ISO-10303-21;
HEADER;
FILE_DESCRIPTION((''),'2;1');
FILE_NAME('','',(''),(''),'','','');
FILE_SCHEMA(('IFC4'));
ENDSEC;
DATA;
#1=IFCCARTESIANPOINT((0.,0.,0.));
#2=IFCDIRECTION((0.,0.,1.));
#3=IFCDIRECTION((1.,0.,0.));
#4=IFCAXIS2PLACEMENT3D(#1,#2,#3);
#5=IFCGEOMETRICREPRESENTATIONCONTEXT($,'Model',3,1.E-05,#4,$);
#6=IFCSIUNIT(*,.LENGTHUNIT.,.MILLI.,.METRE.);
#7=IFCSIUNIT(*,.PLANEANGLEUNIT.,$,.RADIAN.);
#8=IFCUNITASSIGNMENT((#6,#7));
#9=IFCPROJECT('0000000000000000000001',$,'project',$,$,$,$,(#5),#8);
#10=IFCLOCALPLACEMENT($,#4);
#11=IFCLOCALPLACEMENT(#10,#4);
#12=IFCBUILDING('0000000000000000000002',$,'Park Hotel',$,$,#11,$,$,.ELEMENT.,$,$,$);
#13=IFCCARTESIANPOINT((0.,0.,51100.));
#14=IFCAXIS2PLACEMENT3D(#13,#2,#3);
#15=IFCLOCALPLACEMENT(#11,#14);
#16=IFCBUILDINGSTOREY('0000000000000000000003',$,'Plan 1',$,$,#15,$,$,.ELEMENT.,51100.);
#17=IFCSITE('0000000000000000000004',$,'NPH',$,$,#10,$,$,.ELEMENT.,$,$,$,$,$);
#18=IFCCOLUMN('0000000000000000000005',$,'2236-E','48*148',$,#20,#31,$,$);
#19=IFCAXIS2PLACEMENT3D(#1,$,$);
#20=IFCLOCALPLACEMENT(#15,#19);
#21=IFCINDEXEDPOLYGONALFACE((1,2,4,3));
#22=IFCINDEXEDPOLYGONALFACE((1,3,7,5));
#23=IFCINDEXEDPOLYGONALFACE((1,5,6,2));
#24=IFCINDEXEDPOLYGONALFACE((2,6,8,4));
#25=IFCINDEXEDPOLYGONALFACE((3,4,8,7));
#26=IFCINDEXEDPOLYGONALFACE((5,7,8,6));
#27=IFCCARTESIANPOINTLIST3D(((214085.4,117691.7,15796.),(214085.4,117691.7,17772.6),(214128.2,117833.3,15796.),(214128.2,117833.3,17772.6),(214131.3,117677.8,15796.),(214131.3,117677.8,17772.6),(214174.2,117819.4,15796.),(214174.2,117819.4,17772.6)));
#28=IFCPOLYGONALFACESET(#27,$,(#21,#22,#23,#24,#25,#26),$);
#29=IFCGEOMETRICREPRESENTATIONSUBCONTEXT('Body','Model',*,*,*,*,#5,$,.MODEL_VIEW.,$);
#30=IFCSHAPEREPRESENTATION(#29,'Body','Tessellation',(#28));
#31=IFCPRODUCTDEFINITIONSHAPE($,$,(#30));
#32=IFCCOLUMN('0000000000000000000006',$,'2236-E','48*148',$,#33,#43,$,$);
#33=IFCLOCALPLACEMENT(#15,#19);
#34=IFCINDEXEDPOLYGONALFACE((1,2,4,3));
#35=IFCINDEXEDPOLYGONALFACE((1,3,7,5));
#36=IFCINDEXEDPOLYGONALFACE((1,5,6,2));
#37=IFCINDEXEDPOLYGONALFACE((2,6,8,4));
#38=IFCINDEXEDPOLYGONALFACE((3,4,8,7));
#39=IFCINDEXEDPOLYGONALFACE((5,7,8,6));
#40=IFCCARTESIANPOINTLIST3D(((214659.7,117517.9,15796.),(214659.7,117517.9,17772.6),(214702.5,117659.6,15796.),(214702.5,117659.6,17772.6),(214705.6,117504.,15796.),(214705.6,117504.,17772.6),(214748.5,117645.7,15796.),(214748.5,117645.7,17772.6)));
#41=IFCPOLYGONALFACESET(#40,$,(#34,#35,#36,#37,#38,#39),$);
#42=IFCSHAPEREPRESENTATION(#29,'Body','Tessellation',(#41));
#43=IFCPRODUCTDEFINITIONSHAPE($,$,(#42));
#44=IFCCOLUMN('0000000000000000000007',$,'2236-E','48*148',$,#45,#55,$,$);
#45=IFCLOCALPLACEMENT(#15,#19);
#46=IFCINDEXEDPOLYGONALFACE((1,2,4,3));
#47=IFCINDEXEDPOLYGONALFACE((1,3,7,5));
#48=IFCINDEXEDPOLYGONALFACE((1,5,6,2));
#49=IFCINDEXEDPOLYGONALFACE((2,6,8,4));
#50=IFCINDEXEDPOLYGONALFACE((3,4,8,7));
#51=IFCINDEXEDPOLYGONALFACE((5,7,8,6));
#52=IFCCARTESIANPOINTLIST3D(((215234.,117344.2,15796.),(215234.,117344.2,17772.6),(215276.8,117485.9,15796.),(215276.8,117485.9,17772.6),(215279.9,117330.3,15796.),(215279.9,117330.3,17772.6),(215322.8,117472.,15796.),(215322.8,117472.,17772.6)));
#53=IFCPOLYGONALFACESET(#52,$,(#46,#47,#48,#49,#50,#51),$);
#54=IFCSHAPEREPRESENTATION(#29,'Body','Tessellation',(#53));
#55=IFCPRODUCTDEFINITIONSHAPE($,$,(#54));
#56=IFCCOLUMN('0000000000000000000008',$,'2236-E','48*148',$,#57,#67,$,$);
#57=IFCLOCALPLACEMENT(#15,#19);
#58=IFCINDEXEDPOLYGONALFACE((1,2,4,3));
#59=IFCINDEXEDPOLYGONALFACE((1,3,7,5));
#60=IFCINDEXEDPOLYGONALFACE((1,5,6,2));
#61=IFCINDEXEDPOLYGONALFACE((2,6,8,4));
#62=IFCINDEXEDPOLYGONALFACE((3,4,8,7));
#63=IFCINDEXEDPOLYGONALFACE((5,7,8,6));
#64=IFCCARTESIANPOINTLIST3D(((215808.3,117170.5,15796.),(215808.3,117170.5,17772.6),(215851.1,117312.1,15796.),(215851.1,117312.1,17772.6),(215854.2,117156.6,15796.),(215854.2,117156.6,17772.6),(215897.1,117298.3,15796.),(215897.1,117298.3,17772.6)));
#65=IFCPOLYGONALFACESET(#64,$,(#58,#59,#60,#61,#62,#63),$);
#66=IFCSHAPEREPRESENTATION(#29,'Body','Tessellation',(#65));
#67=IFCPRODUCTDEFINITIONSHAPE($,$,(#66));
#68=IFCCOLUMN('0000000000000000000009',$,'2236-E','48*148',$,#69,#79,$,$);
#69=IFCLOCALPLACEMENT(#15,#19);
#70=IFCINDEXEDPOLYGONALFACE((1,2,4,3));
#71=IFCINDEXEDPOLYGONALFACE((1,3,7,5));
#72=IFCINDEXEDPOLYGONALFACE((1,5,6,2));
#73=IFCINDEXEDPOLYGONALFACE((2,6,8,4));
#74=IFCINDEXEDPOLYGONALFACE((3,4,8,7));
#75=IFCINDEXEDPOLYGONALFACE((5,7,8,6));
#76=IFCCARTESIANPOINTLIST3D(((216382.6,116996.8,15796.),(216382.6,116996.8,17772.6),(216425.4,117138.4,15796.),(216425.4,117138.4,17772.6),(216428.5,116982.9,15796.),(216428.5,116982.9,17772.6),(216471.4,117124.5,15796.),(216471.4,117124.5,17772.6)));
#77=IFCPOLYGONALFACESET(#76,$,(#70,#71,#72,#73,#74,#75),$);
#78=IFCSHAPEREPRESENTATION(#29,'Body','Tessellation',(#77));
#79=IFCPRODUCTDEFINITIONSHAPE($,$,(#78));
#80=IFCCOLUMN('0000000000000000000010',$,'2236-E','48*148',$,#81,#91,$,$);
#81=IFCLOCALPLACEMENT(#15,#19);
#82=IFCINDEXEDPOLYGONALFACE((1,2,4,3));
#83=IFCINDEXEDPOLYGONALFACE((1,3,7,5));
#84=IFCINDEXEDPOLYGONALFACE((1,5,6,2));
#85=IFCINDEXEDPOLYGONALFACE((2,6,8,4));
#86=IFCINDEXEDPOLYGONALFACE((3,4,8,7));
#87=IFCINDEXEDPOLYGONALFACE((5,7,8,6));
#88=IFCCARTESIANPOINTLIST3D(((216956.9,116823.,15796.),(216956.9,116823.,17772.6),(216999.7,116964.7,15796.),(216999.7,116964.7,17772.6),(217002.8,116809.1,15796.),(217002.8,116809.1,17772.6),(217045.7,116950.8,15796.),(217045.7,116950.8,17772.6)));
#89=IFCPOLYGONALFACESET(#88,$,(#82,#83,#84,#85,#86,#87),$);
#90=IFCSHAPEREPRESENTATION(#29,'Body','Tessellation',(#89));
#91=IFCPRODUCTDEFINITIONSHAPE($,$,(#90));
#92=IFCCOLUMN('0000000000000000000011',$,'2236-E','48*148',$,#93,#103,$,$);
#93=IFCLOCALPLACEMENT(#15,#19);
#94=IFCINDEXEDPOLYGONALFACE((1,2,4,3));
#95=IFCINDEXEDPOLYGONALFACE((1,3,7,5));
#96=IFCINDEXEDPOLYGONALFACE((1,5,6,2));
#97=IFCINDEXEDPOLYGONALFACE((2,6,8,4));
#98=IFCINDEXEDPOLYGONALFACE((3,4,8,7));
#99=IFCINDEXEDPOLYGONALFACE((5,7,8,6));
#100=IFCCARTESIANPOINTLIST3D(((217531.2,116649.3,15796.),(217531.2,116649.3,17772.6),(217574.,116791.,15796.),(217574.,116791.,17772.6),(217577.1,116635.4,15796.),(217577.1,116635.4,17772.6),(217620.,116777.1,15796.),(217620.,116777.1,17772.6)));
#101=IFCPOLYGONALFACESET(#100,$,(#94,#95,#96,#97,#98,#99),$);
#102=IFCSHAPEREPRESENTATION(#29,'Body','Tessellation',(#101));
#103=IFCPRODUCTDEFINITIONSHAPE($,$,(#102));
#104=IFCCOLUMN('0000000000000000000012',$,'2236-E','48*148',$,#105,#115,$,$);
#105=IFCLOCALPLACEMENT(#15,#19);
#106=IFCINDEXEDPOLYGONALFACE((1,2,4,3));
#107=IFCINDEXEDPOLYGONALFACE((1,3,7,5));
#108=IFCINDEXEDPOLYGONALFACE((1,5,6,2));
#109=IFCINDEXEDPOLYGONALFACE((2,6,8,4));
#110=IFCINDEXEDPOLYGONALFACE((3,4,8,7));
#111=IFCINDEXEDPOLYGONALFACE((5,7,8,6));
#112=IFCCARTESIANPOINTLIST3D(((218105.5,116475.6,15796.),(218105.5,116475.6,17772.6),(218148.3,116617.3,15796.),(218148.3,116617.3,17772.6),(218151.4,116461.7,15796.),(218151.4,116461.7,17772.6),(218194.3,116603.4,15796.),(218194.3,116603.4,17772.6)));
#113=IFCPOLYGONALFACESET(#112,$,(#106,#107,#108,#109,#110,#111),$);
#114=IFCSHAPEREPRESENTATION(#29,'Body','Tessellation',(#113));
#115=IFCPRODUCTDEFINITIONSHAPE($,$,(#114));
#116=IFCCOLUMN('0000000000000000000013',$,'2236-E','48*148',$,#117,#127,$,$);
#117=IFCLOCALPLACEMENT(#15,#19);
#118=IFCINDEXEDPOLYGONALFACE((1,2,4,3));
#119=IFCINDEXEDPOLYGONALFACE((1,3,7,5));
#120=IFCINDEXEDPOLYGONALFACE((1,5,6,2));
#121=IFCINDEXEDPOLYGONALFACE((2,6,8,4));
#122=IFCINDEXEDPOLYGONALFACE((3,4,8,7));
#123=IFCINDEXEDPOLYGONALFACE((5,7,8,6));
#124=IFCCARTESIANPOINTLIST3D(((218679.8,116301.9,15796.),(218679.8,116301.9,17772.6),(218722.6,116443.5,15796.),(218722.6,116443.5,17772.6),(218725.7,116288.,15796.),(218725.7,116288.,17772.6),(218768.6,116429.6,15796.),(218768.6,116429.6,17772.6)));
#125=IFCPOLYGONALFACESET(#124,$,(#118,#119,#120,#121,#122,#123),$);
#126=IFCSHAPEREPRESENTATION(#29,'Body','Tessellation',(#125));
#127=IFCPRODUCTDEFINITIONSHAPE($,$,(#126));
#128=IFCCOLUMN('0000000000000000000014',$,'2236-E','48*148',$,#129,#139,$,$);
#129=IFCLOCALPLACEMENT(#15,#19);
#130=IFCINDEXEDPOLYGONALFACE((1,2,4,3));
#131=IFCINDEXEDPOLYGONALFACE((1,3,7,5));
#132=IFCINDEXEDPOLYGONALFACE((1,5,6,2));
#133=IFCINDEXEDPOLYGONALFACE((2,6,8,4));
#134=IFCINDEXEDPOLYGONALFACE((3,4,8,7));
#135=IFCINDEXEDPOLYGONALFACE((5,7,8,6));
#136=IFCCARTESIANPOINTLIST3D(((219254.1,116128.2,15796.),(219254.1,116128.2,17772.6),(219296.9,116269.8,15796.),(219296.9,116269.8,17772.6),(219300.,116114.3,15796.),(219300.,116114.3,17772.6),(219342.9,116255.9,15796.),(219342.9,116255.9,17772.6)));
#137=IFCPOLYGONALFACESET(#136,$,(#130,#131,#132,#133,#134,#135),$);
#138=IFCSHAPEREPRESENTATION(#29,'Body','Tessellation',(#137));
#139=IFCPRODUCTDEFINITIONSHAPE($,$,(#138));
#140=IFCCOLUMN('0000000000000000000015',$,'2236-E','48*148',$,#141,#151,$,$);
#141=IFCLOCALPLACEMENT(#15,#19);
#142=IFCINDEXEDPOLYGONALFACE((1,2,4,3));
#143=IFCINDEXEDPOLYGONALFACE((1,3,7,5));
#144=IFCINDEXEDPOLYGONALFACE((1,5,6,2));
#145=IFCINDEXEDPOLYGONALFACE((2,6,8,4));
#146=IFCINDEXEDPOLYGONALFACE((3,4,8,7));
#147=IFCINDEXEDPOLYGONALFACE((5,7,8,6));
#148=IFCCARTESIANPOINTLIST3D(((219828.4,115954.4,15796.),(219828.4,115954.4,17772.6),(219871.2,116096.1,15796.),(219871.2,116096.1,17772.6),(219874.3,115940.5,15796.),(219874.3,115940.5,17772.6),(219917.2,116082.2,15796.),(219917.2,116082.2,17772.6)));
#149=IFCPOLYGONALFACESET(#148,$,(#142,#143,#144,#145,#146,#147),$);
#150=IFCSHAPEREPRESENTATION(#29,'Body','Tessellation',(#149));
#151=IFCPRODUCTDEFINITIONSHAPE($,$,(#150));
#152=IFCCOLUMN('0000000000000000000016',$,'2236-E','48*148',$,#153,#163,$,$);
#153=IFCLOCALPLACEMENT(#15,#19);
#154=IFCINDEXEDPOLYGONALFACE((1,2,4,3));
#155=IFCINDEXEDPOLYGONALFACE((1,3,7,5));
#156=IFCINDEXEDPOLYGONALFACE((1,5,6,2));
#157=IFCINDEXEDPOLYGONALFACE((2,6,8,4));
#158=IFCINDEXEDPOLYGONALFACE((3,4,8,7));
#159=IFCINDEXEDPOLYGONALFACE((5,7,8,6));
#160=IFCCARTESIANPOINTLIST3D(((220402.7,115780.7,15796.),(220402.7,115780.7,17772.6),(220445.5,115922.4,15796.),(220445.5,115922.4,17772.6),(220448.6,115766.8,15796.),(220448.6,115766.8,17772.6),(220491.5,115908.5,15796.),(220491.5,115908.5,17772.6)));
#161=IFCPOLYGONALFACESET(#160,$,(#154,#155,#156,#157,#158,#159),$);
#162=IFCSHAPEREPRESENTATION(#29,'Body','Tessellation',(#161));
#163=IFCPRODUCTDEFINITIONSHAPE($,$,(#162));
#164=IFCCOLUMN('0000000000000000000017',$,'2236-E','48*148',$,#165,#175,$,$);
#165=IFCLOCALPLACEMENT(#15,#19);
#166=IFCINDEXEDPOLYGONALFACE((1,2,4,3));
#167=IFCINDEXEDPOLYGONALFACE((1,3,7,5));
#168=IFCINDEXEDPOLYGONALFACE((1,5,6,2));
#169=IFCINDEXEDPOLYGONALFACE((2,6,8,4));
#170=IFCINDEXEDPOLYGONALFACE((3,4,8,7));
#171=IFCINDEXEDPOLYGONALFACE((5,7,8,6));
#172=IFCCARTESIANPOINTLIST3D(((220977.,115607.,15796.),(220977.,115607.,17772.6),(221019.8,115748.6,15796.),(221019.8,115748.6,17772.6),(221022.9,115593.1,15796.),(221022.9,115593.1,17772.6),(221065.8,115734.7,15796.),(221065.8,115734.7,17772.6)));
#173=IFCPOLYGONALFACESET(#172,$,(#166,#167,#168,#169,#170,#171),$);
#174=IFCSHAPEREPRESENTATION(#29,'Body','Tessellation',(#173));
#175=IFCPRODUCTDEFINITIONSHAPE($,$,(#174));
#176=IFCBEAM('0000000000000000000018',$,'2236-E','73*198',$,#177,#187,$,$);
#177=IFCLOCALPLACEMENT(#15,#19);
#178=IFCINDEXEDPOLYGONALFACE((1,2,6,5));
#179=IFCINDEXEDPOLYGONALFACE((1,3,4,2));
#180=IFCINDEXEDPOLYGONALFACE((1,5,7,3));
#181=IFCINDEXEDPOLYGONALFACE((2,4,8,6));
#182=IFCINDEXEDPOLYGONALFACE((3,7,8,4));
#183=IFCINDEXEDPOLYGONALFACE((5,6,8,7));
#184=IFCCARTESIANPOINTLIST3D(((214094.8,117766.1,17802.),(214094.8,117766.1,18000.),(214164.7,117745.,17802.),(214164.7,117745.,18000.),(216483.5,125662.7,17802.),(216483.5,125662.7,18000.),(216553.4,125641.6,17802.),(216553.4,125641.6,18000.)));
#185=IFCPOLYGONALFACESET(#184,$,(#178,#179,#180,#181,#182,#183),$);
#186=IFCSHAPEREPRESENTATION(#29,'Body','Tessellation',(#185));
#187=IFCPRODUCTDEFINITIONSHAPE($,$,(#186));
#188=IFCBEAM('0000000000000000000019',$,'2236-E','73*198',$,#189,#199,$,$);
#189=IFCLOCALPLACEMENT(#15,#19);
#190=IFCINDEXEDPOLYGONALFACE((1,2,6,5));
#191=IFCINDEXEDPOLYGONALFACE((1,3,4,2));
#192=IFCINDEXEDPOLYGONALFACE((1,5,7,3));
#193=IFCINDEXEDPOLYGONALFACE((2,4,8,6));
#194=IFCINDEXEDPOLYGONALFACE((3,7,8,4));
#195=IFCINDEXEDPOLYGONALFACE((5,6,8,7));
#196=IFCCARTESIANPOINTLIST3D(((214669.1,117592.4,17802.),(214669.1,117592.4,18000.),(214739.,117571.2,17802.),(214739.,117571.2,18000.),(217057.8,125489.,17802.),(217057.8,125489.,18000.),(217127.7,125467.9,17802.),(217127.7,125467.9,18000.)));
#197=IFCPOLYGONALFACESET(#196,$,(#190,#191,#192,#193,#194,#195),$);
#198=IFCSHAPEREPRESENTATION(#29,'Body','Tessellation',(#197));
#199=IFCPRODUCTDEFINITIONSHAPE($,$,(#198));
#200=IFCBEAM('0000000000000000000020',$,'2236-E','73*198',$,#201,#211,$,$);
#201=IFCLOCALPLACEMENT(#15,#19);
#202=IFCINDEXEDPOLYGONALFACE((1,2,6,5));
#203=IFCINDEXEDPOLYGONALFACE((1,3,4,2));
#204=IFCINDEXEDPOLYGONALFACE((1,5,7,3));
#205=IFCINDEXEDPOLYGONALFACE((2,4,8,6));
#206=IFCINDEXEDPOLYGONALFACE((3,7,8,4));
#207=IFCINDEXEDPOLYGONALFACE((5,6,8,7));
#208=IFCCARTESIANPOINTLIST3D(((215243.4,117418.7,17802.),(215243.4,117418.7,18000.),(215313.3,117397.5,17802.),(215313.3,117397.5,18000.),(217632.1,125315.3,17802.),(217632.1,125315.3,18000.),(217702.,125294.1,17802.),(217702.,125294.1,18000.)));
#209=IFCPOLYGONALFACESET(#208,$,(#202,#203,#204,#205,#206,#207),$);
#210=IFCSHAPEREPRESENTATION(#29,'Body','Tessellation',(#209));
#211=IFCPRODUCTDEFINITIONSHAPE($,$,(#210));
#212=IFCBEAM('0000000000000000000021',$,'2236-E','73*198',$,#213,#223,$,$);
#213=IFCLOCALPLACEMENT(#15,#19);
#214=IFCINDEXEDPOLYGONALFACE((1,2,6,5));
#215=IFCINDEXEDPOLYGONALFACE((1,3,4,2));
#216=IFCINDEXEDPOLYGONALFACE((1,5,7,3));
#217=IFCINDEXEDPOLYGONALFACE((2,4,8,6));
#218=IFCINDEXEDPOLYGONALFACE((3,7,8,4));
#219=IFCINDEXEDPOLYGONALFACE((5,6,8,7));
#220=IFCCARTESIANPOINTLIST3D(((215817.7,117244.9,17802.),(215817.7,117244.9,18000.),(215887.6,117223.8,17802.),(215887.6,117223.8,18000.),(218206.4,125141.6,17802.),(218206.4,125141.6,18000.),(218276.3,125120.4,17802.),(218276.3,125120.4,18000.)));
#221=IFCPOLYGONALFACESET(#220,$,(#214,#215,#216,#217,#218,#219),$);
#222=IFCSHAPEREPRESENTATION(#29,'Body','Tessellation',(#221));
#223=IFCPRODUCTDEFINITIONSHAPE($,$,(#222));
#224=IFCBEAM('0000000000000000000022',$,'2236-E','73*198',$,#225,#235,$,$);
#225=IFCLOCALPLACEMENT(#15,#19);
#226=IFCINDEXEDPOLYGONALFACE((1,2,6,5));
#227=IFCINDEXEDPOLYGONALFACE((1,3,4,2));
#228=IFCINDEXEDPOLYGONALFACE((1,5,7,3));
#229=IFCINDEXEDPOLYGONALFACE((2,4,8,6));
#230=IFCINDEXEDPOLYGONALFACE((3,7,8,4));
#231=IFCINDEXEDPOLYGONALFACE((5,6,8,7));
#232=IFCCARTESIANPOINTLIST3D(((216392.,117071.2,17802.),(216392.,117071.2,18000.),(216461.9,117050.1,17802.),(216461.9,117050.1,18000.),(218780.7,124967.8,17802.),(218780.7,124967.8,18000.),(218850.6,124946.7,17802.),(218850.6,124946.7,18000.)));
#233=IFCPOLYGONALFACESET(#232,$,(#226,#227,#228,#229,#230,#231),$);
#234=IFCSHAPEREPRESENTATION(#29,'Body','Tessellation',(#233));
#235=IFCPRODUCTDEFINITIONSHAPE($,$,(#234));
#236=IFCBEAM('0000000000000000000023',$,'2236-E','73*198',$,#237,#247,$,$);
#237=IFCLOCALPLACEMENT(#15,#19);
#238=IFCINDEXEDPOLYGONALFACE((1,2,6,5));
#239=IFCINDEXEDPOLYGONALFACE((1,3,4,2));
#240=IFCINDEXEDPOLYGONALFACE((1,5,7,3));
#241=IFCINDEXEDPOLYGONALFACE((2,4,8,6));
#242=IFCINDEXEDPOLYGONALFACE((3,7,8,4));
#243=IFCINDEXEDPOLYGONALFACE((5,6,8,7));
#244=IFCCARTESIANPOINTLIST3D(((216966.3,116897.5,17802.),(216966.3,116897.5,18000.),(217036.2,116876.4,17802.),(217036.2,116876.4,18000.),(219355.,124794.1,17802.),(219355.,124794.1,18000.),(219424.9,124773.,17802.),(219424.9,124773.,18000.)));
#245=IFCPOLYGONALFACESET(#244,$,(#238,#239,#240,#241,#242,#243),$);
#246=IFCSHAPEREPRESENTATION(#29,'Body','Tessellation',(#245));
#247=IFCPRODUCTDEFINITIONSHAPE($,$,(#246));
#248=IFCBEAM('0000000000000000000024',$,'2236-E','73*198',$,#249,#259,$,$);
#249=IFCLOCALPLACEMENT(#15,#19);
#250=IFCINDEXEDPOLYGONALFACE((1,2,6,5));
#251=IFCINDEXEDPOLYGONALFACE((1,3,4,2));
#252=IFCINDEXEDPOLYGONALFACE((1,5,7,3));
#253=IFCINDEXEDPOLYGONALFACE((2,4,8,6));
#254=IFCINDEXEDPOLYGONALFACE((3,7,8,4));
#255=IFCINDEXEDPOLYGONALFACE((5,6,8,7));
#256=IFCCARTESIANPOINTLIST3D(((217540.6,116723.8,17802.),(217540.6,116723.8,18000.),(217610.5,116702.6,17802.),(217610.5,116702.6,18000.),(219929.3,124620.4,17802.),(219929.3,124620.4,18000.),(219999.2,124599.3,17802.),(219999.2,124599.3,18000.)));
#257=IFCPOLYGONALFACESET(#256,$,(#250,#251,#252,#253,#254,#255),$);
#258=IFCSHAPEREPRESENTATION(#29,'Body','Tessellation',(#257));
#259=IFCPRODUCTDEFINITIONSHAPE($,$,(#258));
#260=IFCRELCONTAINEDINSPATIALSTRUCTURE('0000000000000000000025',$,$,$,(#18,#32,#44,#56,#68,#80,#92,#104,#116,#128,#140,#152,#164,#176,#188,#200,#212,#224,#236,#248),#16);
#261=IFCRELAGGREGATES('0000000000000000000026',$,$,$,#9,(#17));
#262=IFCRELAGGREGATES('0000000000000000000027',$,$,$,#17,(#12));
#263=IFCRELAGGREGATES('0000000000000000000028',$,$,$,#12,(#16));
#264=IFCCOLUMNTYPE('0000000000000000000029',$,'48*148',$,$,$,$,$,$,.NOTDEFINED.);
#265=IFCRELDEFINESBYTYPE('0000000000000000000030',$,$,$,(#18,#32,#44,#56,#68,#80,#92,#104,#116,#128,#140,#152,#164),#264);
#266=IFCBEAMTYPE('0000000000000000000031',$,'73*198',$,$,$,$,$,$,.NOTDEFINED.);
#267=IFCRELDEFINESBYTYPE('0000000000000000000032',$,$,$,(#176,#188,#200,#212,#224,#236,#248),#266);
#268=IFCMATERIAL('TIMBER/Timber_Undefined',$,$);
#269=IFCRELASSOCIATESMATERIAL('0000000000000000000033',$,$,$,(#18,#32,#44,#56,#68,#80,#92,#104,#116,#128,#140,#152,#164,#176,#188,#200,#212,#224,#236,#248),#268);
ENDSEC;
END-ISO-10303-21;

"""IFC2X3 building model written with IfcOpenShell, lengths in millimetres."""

from ifc_helpers import new_model, si_unit, frame, origin_with_axes, origin_2d_with_axis, place, context, subcontext, project, spatial, rectangle, extrude, material, type_object, element, save


model = new_model("IFC2X3")

# Units and contexts
model_context = context("Model", 3, precision=1e-05, world=origin_with_axes())
body_context = subcontext(model_context, "Body", "Model", "MODEL_VIEW")
ifc_project = project(units=[si_unit("LENGTHUNIT", "METRE", prefix="MILLI"), si_unit("PLANEANGLEUNIT", "RADIAN")], contexts=[model_context])

# Site, building, storey
site_placement = place(None, origin_with_axes())
site = spatial("IfcSite", under=ifc_project, at=site_placement, Name="NPH", CompositionType="ELEMENT")
building_placement = place(site_placement, origin_with_axes())
building = spatial("IfcBuilding", under=site, at=building_placement, Name="Park Hotel", CompositionType="ELEMENT")
storey_placement = place(building_placement, frame((0.0, 0.0, 51100.0), z_axis=(0.0, 0.0, 1.0), x_axis=(1.0, 0.0, 0.0)))
storey = spatial("IfcBuildingStorey", under=building, at=storey_placement, Name="Plan 1", CompositionType="ELEMENT", Elevation=51100.0)

# Columns
ifc_material = material(Name="TIMBER/Timber_Undefined")
column_type = type_object("IfcColumnType", Name="48*148", PredefinedType="NOTDEFINED")
for number, where, z_axis, x_axis, name in (
    (1, (214129.8, 117755.5, 17772.6), (0.0, 0.0, -1.0), (0.957167, -0.289538, 0.0), "2236-E"),
    (2, (214704.1, 117581.8, 17772.6), (0.0, 0.0, -1.0), (0.957167, -0.289538, 0.0), "2236-E"),
    (3, (215278.4, 117408.1, 17772.6), (0.0, 0.0, -1.0), (0.957167, -0.289538, 0.0), "2236-E"),
    (4, (215852.7, 117234.4, 17772.6), (0.0, 0.0, -1.0), (0.957167, -0.289538, 0.0), "2236-E"),
    (5, (216427.0, 117060.6, 17772.6), (0.0, 0.0, -1.0), (0.957167, -0.289538, 0.0), "2236-E"),
    (6, (217001.3, 116886.9, 17772.6), (0.0, 0.0, -1.0), (0.957167, -0.289538, 0.0), "2236-E"),
    (7, (217575.6, 116713.2, 17772.6), (0.0, 0.0, -1.0), (0.957167, -0.289538, 0.0), "2236-E"),
    (8, (218149.9, 116539.5, 17772.6), (0.0, 0.0, -1.0), (0.957167, -0.289538, 0.0), "2236-E"),
    (9, (218724.2, 116365.8, 17772.6), (0.0, 0.0, -1.0), (0.957167, -0.289538, 0.0), "2236-E"),
    (10, (219298.5, 116192.0, 17772.6), (0.0, 0.0, -1.0), (0.957167, -0.289538, 0.0), "2236-E"),
    (11, (219872.8, 116018.3, 17772.6), (0.0, 0.0, -1.0), (0.957167, -0.289538, 0.0), "2236-E"),
    (12, (220447.1, 115844.6, 17772.6), (0.0, 0.0, -1.0), (0.957167, -0.289538, 0.0), "2236-E"),
    (13, (221021.4, 115670.9, 17772.6), (0.0, 0.0, -1.0), (0.957167, -0.289538, 0.0), "2236-E"),
):
    element("IfcColumn", number, at=place(storey_placement, frame(where, z_axis=z_axis, x_axis=x_axis)), inside=storey, type_object=column_type, material=ifc_material, Name=name, Description="48*148", context=body_context, shape_type="SweptSolid", body=[
        extrude(rectangle(XDim=148.0, YDim=48.0, at=origin_2d_with_axis()), frame((0.0, 0.0, 1976.6), z_axis=(0.0, 0.0, -1.0), x_axis=(0.0, 1.0, 0.0)), (0.0, 0.0, 1.0), 1976.6),
    ])

# Beams
beam_type = type_object("IfcBeamType", Name="73*198", PredefinedType="NOTDEFINED")
for number, where, z_axis, x_axis, name in (
    (14, (214129.8, 117755.5, 17901.0), (-0.957167, 0.289538, 0.0), (0.289538, 0.957167, 0.0), "2236-E"),
    (15, (214704.1, 117581.8, 17901.0), (-0.957167, 0.289538, 0.0), (0.289538, 0.957167, 0.0), "2236-E"),
    (16, (215278.4, 117408.1, 17901.0), (-0.957167, 0.289538, 0.0), (0.289538, 0.957167, 0.0), "2236-E"),
    (17, (215852.7, 117234.4, 17901.0), (-0.957167, 0.289538, 0.0), (0.289538, 0.957167, 0.0), "2236-E"),
    (18, (216427.0, 117060.6, 17901.0), (-0.957167, 0.289538, 0.0), (0.289538, 0.957167, 0.0), "2236-E"),
    (19, (217001.3, 116886.9, 17901.0), (-0.957167, 0.289538, 0.0), (0.289538, 0.957167, 0.0), "2236-E"),
    (20, (217575.6, 116713.2, 17901.0), (-0.957167, 0.289538, 0.0), (0.289538, 0.957167, 0.0), "2236-E"),
):
    element("IfcBeam", number, at=place(storey_placement, frame(where, z_axis=z_axis, x_axis=x_axis)), inside=storey, type_object=beam_type, material=ifc_material, Name=name, Description="73*198", context=body_context, shape_type="SweptSolid", body=[
        extrude(rectangle(XDim=198.0, YDim=73.0, at=origin_2d_with_axis()), frame((8250.0, 0.0, 0.0), z_axis=(-1.0, 0.0, 0.0), x_axis=(0.0, -1.0, 0.0)), (0.0, 0.0, 1.0), 8250.0),
    ])

save(model, "model.ifc")
